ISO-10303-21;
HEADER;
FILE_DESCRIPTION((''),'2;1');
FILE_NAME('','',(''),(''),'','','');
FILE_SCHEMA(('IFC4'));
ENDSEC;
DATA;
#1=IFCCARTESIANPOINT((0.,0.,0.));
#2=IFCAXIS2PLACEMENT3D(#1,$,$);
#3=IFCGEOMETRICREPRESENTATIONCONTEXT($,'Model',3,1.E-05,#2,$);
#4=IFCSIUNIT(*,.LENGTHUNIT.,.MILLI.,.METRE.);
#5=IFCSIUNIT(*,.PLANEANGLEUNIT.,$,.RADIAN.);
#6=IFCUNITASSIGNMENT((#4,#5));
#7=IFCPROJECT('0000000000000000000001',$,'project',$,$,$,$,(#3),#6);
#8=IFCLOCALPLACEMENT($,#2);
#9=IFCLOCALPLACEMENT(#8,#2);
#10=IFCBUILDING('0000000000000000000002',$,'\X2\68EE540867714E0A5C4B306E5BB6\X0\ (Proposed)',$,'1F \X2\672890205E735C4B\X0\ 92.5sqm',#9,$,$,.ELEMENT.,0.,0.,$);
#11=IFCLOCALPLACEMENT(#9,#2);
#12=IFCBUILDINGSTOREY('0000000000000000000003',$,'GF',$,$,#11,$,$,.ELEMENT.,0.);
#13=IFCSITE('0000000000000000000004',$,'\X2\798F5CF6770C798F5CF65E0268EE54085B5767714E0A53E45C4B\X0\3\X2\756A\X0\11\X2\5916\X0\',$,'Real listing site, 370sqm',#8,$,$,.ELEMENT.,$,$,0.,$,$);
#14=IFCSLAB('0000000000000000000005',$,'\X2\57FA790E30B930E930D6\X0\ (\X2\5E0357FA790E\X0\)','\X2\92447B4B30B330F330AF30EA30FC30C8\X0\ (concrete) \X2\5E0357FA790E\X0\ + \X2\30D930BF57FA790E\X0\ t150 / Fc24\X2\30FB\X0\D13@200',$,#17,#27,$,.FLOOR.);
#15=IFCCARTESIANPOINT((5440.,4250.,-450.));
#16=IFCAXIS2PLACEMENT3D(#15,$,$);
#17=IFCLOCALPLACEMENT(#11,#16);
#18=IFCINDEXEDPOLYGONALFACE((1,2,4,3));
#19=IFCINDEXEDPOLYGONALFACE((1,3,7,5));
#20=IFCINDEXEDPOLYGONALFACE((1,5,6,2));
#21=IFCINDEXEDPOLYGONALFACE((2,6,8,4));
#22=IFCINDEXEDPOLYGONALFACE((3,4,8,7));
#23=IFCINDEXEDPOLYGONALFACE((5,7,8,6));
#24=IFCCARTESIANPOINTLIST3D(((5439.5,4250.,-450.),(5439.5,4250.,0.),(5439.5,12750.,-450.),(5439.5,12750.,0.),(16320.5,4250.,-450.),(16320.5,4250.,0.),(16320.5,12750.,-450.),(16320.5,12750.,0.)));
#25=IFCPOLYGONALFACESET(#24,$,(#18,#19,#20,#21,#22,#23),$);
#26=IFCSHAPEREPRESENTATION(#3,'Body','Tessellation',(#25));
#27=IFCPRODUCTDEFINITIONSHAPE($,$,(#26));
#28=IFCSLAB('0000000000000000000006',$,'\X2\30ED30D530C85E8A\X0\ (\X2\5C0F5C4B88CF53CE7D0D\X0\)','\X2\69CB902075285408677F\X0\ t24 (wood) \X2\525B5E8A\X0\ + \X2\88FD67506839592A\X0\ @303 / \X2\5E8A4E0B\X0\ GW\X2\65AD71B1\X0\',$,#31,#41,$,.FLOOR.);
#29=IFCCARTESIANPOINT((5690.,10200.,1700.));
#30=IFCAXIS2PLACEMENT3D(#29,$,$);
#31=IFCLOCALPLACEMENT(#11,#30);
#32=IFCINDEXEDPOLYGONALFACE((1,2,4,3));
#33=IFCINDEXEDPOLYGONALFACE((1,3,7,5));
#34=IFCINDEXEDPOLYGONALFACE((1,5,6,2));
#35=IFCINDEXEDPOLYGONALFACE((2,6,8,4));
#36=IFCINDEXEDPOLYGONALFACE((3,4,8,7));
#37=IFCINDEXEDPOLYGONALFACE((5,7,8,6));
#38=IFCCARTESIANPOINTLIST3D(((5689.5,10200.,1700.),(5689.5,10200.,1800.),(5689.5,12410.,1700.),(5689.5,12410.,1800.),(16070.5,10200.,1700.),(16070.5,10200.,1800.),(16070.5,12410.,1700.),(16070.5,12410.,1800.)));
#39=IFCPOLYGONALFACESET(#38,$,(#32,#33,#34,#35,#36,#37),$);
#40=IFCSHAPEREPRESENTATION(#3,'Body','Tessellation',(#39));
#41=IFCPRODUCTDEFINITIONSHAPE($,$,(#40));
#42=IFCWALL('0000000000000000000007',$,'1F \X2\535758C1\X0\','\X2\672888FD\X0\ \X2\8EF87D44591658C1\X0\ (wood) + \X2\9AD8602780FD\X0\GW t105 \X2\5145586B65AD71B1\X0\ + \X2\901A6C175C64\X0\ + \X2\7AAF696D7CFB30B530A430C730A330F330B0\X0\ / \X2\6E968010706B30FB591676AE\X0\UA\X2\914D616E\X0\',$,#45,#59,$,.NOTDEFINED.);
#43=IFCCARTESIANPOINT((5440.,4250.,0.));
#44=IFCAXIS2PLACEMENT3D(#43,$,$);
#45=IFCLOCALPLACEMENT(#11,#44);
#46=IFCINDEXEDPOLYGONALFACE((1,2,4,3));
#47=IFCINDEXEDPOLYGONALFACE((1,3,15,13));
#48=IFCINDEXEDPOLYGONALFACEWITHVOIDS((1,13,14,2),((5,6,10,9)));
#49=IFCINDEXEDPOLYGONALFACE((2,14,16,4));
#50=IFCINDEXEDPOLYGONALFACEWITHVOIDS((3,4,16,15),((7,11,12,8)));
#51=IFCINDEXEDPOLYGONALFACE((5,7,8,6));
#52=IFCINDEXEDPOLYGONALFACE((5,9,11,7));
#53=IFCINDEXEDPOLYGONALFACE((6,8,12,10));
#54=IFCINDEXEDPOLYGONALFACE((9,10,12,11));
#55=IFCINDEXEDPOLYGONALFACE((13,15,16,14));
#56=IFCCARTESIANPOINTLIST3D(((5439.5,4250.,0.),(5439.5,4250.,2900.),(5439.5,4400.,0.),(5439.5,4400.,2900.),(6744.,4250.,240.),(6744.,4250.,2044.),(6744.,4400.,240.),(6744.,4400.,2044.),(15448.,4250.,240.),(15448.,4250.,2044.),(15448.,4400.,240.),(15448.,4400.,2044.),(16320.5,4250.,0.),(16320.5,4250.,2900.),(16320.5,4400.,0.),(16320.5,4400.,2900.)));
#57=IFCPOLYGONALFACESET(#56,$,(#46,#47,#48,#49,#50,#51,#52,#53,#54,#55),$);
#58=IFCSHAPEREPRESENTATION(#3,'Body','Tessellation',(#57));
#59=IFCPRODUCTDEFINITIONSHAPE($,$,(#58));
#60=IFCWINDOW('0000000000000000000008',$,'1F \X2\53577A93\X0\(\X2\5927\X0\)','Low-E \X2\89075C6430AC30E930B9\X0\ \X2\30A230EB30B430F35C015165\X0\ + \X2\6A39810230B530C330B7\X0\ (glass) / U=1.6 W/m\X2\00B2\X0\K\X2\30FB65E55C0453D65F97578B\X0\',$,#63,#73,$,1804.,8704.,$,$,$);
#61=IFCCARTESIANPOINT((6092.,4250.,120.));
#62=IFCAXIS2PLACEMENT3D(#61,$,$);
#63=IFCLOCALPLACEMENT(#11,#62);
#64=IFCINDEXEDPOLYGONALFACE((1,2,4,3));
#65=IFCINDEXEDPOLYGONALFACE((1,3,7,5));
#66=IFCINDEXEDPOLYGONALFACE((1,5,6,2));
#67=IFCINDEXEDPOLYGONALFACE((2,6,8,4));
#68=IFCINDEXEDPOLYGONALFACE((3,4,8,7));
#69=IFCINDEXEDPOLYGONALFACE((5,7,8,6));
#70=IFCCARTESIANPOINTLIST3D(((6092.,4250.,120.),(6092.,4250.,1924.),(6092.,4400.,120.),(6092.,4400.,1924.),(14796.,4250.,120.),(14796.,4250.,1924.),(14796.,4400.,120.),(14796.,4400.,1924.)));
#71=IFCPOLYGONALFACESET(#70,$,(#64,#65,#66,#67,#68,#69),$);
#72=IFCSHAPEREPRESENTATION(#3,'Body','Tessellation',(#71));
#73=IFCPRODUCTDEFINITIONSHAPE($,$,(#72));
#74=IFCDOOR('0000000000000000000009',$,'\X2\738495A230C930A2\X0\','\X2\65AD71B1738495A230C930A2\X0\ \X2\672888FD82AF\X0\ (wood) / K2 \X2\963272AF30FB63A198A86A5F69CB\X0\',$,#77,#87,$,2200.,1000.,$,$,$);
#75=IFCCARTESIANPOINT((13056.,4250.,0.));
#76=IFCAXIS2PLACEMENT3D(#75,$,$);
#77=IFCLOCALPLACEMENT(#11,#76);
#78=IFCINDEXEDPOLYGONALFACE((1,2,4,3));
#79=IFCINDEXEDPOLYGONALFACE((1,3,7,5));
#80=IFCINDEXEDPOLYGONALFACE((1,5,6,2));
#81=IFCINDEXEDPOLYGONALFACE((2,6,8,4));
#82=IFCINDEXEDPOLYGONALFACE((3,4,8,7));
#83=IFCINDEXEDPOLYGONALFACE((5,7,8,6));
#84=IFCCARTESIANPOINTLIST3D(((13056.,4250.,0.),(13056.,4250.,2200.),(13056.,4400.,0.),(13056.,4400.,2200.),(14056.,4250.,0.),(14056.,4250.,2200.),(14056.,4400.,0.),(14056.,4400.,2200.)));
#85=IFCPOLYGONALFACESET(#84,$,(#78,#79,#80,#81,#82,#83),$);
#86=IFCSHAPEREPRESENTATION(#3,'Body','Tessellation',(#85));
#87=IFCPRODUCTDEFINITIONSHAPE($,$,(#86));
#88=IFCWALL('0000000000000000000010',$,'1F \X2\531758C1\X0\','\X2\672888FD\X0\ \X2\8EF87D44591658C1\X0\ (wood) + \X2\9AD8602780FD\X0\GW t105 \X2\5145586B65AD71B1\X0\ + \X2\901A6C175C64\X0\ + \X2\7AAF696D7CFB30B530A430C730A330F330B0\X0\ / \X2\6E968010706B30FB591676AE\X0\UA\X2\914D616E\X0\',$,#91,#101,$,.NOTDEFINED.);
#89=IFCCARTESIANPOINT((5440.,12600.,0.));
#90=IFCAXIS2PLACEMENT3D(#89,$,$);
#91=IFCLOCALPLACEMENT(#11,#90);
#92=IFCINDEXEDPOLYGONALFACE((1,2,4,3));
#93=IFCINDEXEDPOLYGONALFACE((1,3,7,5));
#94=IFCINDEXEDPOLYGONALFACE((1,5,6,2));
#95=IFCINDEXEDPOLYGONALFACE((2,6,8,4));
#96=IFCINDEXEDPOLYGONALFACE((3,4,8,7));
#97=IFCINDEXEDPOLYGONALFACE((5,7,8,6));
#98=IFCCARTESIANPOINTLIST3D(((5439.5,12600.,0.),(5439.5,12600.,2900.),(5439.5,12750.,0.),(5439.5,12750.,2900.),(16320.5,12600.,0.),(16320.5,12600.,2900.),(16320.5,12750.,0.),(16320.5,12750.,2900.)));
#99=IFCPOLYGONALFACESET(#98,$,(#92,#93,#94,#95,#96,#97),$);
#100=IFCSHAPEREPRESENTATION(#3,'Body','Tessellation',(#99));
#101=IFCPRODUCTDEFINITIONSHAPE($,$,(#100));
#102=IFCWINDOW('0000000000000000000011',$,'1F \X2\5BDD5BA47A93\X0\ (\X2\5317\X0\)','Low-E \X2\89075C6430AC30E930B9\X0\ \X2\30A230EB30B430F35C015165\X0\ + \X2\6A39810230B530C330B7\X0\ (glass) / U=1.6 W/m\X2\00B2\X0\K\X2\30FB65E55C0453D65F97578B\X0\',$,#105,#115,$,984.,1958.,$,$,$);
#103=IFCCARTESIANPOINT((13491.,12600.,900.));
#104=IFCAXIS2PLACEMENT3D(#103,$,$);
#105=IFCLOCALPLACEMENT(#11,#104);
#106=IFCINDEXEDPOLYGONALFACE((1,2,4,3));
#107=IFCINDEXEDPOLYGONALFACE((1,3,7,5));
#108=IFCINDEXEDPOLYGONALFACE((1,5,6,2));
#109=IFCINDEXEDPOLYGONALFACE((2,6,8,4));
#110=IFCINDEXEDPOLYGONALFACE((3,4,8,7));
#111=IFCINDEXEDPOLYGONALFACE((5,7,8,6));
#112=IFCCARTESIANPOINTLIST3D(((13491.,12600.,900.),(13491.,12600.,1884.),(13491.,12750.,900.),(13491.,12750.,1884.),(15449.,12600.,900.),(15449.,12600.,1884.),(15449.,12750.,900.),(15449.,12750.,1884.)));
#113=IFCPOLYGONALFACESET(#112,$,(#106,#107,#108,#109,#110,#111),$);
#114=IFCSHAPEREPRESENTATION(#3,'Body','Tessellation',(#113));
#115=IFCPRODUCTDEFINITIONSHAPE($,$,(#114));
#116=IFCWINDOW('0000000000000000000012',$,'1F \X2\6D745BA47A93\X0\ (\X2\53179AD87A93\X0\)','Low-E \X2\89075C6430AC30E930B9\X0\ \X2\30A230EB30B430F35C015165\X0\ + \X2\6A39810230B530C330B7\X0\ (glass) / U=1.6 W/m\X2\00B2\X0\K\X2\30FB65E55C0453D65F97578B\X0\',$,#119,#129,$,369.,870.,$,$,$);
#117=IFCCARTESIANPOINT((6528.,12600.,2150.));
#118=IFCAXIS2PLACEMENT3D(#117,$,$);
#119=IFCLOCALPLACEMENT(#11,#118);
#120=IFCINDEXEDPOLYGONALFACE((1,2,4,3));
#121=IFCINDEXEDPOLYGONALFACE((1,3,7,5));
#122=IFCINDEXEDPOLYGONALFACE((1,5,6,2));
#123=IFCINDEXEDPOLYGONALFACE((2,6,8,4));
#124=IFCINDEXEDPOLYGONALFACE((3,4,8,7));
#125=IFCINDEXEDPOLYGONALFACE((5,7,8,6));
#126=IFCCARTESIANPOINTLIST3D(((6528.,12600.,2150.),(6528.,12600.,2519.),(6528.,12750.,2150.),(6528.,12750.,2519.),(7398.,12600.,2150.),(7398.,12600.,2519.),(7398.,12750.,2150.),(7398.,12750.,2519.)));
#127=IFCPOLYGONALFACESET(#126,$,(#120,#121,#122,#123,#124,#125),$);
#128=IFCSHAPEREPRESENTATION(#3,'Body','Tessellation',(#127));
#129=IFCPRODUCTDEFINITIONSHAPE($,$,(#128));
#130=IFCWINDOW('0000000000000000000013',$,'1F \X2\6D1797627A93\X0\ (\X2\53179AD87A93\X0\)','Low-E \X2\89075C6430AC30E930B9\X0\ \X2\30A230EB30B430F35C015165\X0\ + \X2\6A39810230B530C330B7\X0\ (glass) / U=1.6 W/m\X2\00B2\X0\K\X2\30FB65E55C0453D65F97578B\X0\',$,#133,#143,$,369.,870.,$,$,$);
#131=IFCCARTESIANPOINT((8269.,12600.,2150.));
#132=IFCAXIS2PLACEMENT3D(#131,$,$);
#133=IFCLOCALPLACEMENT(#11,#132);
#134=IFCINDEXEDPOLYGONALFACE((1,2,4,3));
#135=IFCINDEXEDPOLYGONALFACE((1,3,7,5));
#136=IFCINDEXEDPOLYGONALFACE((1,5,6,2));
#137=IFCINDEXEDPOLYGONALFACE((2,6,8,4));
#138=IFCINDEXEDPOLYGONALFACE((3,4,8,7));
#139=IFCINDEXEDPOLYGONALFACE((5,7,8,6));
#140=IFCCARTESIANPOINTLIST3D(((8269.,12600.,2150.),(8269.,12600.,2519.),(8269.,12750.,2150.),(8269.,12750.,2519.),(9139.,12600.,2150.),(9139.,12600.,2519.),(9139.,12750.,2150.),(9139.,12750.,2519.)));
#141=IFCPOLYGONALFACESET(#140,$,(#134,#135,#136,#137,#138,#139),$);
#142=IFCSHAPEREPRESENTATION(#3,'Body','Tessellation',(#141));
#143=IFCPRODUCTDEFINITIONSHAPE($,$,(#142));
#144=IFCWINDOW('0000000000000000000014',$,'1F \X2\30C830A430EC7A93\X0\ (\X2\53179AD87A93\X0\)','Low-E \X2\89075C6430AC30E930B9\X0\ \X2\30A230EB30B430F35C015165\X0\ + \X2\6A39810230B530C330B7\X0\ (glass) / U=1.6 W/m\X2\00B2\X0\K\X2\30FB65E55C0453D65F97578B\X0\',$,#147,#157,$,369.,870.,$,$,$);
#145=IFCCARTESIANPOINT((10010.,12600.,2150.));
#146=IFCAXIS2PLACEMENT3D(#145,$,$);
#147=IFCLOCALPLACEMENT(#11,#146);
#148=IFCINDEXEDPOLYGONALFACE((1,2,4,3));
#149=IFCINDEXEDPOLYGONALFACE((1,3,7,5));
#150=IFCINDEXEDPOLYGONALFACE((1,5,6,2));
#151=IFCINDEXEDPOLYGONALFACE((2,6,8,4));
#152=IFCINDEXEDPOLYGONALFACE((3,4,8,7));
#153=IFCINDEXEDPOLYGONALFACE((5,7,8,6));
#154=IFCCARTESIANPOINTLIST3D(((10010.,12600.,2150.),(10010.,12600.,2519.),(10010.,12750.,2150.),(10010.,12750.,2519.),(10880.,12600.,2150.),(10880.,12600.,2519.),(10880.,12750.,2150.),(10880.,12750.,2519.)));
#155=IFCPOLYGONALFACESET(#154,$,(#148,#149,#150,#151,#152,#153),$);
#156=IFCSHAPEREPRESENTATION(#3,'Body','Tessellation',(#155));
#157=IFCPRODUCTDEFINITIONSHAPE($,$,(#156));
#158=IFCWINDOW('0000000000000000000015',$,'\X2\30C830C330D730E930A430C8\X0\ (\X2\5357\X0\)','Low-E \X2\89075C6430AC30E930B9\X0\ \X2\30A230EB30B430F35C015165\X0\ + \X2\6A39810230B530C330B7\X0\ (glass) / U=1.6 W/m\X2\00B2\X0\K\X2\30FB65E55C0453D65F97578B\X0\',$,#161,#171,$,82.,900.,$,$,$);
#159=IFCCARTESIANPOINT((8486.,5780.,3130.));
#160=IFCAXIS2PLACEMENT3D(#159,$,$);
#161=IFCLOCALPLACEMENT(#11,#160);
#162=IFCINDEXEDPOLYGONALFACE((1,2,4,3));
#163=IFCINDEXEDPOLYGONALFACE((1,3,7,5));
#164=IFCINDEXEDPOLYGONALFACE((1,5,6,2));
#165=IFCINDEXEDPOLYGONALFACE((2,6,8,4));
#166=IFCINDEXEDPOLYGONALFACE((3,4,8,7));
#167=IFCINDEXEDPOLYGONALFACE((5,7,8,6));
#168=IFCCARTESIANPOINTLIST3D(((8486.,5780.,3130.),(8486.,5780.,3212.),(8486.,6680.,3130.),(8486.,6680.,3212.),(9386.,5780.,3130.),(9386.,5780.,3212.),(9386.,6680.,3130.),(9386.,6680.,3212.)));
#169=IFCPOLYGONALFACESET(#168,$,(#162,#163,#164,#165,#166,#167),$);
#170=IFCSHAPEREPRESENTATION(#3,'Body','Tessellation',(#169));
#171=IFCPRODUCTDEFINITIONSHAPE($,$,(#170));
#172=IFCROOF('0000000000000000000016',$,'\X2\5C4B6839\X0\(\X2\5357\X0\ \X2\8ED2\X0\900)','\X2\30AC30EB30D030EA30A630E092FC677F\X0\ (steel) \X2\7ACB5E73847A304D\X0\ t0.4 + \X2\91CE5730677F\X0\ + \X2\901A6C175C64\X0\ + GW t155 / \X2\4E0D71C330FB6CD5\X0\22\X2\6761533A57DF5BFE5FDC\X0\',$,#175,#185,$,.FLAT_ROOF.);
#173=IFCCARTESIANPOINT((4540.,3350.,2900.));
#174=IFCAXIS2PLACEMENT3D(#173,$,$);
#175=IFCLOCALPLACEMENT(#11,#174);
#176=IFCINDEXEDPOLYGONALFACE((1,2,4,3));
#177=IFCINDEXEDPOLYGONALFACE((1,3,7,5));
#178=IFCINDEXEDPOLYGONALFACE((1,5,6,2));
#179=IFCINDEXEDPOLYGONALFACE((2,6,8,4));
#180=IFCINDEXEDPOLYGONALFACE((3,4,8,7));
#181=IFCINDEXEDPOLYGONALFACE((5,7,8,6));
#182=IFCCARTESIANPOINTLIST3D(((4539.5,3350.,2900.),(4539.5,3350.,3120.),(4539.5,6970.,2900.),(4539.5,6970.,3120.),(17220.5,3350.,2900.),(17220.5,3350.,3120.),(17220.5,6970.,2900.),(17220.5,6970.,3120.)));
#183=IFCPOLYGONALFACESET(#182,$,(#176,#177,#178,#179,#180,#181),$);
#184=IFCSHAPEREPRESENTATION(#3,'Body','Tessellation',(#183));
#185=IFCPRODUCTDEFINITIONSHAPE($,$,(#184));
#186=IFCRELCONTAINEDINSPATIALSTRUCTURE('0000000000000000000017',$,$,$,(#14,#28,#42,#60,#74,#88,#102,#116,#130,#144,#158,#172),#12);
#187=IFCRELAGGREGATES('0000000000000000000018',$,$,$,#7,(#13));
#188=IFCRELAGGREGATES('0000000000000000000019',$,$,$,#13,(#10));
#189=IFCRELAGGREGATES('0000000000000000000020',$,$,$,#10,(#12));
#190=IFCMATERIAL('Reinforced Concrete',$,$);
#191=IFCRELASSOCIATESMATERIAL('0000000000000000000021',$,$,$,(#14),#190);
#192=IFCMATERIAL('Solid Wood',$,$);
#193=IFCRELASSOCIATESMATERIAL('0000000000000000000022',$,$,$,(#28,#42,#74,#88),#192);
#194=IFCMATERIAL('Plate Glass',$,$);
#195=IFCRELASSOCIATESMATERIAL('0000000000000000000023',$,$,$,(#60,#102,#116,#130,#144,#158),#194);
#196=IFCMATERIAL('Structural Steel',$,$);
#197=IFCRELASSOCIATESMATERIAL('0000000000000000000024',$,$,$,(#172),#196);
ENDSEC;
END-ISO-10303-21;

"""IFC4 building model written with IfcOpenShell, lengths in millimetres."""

from ifc_helpers import new_model, si_unit, frame, frame_2d, origin, place, context, project, spatial, rectangle, extrude, material, element, fill, save


model = new_model("IFC4")

# Units and contexts
model_context = context("Model", 3, precision=1e-05, world=origin())
ifc_project = project(units=[si_unit("LENGTHUNIT", "METRE", prefix="MILLI"), si_unit("PLANEANGLEUNIT", "RADIAN")], contexts=[model_context])

# Site, building, storey
site_placement = place(None, origin())
site = spatial("IfcSite", under=ifc_project, at=site_placement, Name="福島県福島市森合字東上古屋3番11外", ObjectType="Real listing site, 370sqm", CompositionType="ELEMENT", RefElevation=0.0)
building_placement = place(site_placement, origin())
building = spatial("IfcBuilding", under=site, at=building_placement, Name="森合東上屋の家 (Proposed)", ObjectType="1F 木造平屋 92.5sqm", CompositionType="ELEMENT", ElevationOfRefHeight=0.0, ElevationOfTerrain=0.0)
storey_placement = place(building_placement, origin())
storey = spatial("IfcBuildingStorey", under=building, at=storey_placement, Name="GF", CompositionType="ELEMENT", Elevation=0.0)

# Slabs
ifc_material_1 = material(Name="Reinforced Concrete")
slab_1_placement = place(storey_placement, frame((5440.0, 4250.0, -450.0)))
element("IfcSlab", 1, at=slab_1_placement, inside=storey, material=ifc_material_1, Name="基礎スラブ (布基礎)", Description="鉄筋コンクリート (concrete) 布基礎 + ベタ基礎 t150 / Fc24・D13@200", PredefinedType="FLOOR", context=model_context, shape_type="SweptSolid", body=[
    extrude(rectangle(XDim=10881.0, YDim=8500.0, at=frame_2d((5440.0, 4250.0))), frame((5440.0, 4250.0, -450.0)), (0.0, 0.0, 1.0), 450.0),
])
ifc_material_2 = material(Name="Solid Wood")
slab_2_placement = place(storey_placement, frame((5690.0, 10200.0, 1700.0)))
element("IfcSlab", 2, at=slab_2_placement, inside=storey, material=ifc_material_2, Name="ロフト床 (小屋裏収納)", Description="構造用合板 t24 (wood) 剛床 + 製材根太 @303 / 床下 GW断熱", PredefinedType="FLOOR", context=model_context, shape_type="SweptSolid", body=[
    extrude(rectangle(XDim=10381.0, YDim=2210.0, at=frame_2d((5190.0, 1105.0))), frame((5690.0, 10200.0, 1700.0)), (0.0, 0.0, 1.0), 100.0),
])

# Wall, openings, window, door
wall_1_placement = place(storey_placement, frame((5440.0, 4250.0, 0.0)))
wall_1 = element("IfcWall", 3, at=wall_1_placement, inside=storey, material=ifc_material_2, Name="1F 南壁", Description="木製 軸組外壁 (wood) + 高性能GW t105 充填断熱 + 通気層 + 窯業系サイディング / 準耐火・外皮UA配慮", PredefinedType="NOTDEFINED", context=model_context, shape_type="SweptSolid", body=[
    extrude(rectangle(XDim=10881.0, YDim=150.0, at=frame_2d((5440.0, 75.0))), frame((5440.0, 4250.0, 0.0)), (0.0, 0.0, 1.0), 2900.0),
])
opening_1_placement = place(storey_placement, frame((6092.0, 4250.0, 120.0)))
opening_1 = element("IfcOpeningElement", 4, at=opening_1_placement, cuts=wall_1, PredefinedType="NOTDEFINED", context=model_context, shape_type="SweptSolid", body=[
    extrude(rectangle(XDim=8704.0, YDim=150.0, at=frame_2d((4352.0, 75.0))), frame((6092.0, 4250.0, 120.0)), (0.0, 0.0, 1.0), 1804.0),
])
opening_2_placement = place(storey_placement, frame((13056.0, 4250.0, 0.0)))
opening_2 = element("IfcOpeningElement", 5, at=opening_2_placement, cuts=wall_1, PredefinedType="NOTDEFINED", context=model_context, shape_type="SweptSolid", body=[
    extrude(rectangle(XDim=1000.0, YDim=150.0, at=frame_2d((500.0, 75.0))), frame((13056.0, 4250.0, 0.0)), (0.0, 0.0, 1.0), 2200.0),
])
ifc_material_3 = material(Name="Plate Glass")
window_1_placement = place(storey_placement, frame((6092.0, 4250.0, 120.0)))
window_1 = element("IfcWindow", 6, at=window_1_placement, inside=storey, material=ifc_material_3, Name="1F 南窓(大)", Description="Low-E 複層ガラス アルゴン封入 + 樹脂サッシ (glass) / U=1.6 W/m²K・日射取得型", OverallHeight=1804.0, OverallWidth=8704.0, context=model_context, shape_type="SweptSolid", body=[
    extrude(rectangle(XDim=8704.0, YDim=150.0, at=frame_2d((4352.0, 75.0))), frame((6092.0, 4250.0, 120.0)), (0.0, 0.0, 1.0), 1804.0),
])
fill(opening_1, window_1)
door_1_placement = place(storey_placement, frame((13056.0, 4250.0, 0.0)))
door_1 = element("IfcDoor", 7, at=door_1_placement, inside=storey, material=ifc_material_2, Name="玄関ドア", Description="断熱玄関ドア 木製芯 (wood) / K2 防犯・採風機構", OverallHeight=2200.0, OverallWidth=1000.0, context=model_context, shape_type="SweptSolid", body=[
    extrude(rectangle(XDim=1000.0, YDim=150.0, at=frame_2d((500.0, 75.0))), frame((13056.0, 4250.0, 0.0)), (0.0, 0.0, 1.0), 2200.0),
])
fill(opening_2, door_1)

# Wall, openings, windows
wall_2_placement = place(storey_placement, frame((5440.0, 12600.0, 0.0)))
wall_2 = element("IfcWall", 8, at=wall_2_placement, inside=storey, material=ifc_material_2, Name="1F 北壁", Description="木製 軸組外壁 (wood) + 高性能GW t105 充填断熱 + 通気層 + 窯業系サイディング / 準耐火・外皮UA配慮", PredefinedType="NOTDEFINED", context=model_context, shape_type="SweptSolid", body=[
    extrude(rectangle(XDim=10881.0, YDim=150.0, at=frame_2d((5440.0, 75.0))), frame((5440.0, 12600.0, 0.0)), (0.0, 0.0, 1.0), 2900.0),
])
opening_3_placement = place(storey_placement, frame((13491.0, 12600.0, 900.0)))
opening_3 = element("IfcOpeningElement", 9, at=opening_3_placement, cuts=wall_2, PredefinedType="NOTDEFINED", context=model_context, shape_type="SweptSolid", body=[
    extrude(rectangle(XDim=1958.0, YDim=150.0, at=frame_2d((979.0, 75.0))), frame((13491.0, 12600.0, 900.0)), (0.0, 0.0, 1.0), 984.0),
])
opening_4_placement = place(storey_placement, frame((6528.0, 12600.0, 2150.0)))
opening_4 = element("IfcOpeningElement", 10, at=opening_4_placement, cuts=wall_2, PredefinedType="NOTDEFINED", context=model_context, shape_type="SweptSolid", body=[
    extrude(rectangle(XDim=870.0, YDim=150.0, at=frame_2d((435.0, 75.0))), frame((6528.0, 12600.0, 2150.0)), (0.0, 0.0, 1.0), 369.0),
])
opening_5_placement = place(storey_placement, frame((8269.0, 12600.0, 2150.0)))
opening_5 = element("IfcOpeningElement", 11, at=opening_5_placement, cuts=wall_2, PredefinedType="NOTDEFINED", context=model_context, shape_type="SweptSolid", body=[
    extrude(rectangle(XDim=870.0, YDim=150.0, at=frame_2d((435.0, 75.0))), frame((8269.0, 12600.0, 2150.0)), (0.0, 0.0, 1.0), 369.0),
])
opening_6_placement = place(storey_placement, frame((10010.0, 12600.0, 2150.0)))
opening_6 = element("IfcOpeningElement", 12, at=opening_6_placement, cuts=wall_2, PredefinedType="NOTDEFINED", context=model_context, shape_type="SweptSolid", body=[
    extrude(rectangle(XDim=870.0, YDim=150.0, at=frame_2d((435.0, 75.0))), frame((10010.0, 12600.0, 2150.0)), (0.0, 0.0, 1.0), 369.0),
])
window_2_placement = place(storey_placement, frame((13491.0, 12600.0, 900.0)))
window_2 = element("IfcWindow", 13, at=window_2_placement, inside=storey, material=ifc_material_3, Name="1F 寝室窓 (北)", Description="Low-E 複層ガラス アルゴン封入 + 樹脂サッシ (glass) / U=1.6 W/m²K・日射取得型", OverallHeight=984.0, OverallWidth=1958.0, context=model_context, shape_type="SweptSolid", body=[
    extrude(rectangle(XDim=1958.0, YDim=150.0, at=frame_2d((979.0, 75.0))), frame((13491.0, 12600.0, 900.0)), (0.0, 0.0, 1.0), 984.0),
])
fill(opening_3, window_2)
window_3_placement = place(storey_placement, frame((6528.0, 12600.0, 2150.0)))
window_3 = element("IfcWindow", 14, at=window_3_placement, inside=storey, material=ifc_material_3, Name="1F 浴室窓 (北高窓)", Description="Low-E 複層ガラス アルゴン封入 + 樹脂サッシ (glass) / U=1.6 W/m²K・日射取得型", OverallHeight=369.0, OverallWidth=870.0, context=model_context, shape_type="SweptSolid", body=[
    extrude(rectangle(XDim=870.0, YDim=150.0, at=frame_2d((435.0, 75.0))), frame((6528.0, 12600.0, 2150.0)), (0.0, 0.0, 1.0), 369.0),
])
fill(opening_4, window_3)
window_4_placement = place(storey_placement, frame((8269.0, 12600.0, 2150.0)))
window_4 = element("IfcWindow", 15, at=window_4_placement, inside=storey, material=ifc_material_3, Name="1F 洗面窓 (北高窓)", Description="Low-E 複層ガラス アルゴン封入 + 樹脂サッシ (glass) / U=1.6 W/m²K・日射取得型", OverallHeight=369.0, OverallWidth=870.0, context=model_context, shape_type="SweptSolid", body=[
    extrude(rectangle(XDim=870.0, YDim=150.0, at=frame_2d((435.0, 75.0))), frame((8269.0, 12600.0, 2150.0)), (0.0, 0.0, 1.0), 369.0),
])
fill(opening_5, window_4)
window_5_placement = place(storey_placement, frame((10010.0, 12600.0, 2150.0)))
window_5 = element("IfcWindow", 16, at=window_5_placement, inside=storey, material=ifc_material_3, Name="1F トイレ窓 (北高窓)", Description="Low-E 複層ガラス アルゴン封入 + 樹脂サッシ (glass) / U=1.6 W/m²K・日射取得型", OverallHeight=369.0, OverallWidth=870.0, context=model_context, shape_type="SweptSolid", body=[
    extrude(rectangle(XDim=870.0, YDim=150.0, at=frame_2d((435.0, 75.0))), frame((10010.0, 12600.0, 2150.0)), (0.0, 0.0, 1.0), 369.0),
])
fill(opening_6, window_5)

# Window
window_6_placement = place(storey_placement, frame((8486.0, 5780.0, 3130.0)))
element("IfcWindow", 17, at=window_6_placement, inside=storey, material=ifc_material_3, Name="トップライト (南)", Description="Low-E 複層ガラス アルゴン封入 + 樹脂サッシ (glass) / U=1.6 W/m²K・日射取得型", OverallHeight=82.0, OverallWidth=900.0, context=model_context, shape_type="SweptSolid", body=[
    extrude(rectangle(XDim=900.0, YDim=900.0, at=frame_2d((450.0, 450.0))), frame((8486.0, 5780.0, 3130.0)), (0.0, 0.0, 1.0), 82.0),
])

# Roof
ifc_material_4 = material(Name="Structural Steel")
roof_1_placement = place(storey_placement, frame((4540.0, 3350.0, 2900.0)))
element("IfcRoof", 18, at=roof_1_placement, inside=storey, material=ifc_material_4, Name="屋根(南 軒900)", Description="ガルバリウム鋼板 (steel) 立平葺き t0.4 + 野地板 + 通気層 + GW t155 / 不燃・法22条区域対応", PredefinedType="FLAT_ROOF", context=model_context, shape_type="SweptSolid", body=[
    extrude(rectangle(XDim=12681.0, YDim=3620.0, at=frame_2d((6340.0, 1810.0))), frame((4540.0, 3350.0, 2900.0)), (0.0, 0.0, 1.0), 220.0),
])

save(model, "model.ifc")
